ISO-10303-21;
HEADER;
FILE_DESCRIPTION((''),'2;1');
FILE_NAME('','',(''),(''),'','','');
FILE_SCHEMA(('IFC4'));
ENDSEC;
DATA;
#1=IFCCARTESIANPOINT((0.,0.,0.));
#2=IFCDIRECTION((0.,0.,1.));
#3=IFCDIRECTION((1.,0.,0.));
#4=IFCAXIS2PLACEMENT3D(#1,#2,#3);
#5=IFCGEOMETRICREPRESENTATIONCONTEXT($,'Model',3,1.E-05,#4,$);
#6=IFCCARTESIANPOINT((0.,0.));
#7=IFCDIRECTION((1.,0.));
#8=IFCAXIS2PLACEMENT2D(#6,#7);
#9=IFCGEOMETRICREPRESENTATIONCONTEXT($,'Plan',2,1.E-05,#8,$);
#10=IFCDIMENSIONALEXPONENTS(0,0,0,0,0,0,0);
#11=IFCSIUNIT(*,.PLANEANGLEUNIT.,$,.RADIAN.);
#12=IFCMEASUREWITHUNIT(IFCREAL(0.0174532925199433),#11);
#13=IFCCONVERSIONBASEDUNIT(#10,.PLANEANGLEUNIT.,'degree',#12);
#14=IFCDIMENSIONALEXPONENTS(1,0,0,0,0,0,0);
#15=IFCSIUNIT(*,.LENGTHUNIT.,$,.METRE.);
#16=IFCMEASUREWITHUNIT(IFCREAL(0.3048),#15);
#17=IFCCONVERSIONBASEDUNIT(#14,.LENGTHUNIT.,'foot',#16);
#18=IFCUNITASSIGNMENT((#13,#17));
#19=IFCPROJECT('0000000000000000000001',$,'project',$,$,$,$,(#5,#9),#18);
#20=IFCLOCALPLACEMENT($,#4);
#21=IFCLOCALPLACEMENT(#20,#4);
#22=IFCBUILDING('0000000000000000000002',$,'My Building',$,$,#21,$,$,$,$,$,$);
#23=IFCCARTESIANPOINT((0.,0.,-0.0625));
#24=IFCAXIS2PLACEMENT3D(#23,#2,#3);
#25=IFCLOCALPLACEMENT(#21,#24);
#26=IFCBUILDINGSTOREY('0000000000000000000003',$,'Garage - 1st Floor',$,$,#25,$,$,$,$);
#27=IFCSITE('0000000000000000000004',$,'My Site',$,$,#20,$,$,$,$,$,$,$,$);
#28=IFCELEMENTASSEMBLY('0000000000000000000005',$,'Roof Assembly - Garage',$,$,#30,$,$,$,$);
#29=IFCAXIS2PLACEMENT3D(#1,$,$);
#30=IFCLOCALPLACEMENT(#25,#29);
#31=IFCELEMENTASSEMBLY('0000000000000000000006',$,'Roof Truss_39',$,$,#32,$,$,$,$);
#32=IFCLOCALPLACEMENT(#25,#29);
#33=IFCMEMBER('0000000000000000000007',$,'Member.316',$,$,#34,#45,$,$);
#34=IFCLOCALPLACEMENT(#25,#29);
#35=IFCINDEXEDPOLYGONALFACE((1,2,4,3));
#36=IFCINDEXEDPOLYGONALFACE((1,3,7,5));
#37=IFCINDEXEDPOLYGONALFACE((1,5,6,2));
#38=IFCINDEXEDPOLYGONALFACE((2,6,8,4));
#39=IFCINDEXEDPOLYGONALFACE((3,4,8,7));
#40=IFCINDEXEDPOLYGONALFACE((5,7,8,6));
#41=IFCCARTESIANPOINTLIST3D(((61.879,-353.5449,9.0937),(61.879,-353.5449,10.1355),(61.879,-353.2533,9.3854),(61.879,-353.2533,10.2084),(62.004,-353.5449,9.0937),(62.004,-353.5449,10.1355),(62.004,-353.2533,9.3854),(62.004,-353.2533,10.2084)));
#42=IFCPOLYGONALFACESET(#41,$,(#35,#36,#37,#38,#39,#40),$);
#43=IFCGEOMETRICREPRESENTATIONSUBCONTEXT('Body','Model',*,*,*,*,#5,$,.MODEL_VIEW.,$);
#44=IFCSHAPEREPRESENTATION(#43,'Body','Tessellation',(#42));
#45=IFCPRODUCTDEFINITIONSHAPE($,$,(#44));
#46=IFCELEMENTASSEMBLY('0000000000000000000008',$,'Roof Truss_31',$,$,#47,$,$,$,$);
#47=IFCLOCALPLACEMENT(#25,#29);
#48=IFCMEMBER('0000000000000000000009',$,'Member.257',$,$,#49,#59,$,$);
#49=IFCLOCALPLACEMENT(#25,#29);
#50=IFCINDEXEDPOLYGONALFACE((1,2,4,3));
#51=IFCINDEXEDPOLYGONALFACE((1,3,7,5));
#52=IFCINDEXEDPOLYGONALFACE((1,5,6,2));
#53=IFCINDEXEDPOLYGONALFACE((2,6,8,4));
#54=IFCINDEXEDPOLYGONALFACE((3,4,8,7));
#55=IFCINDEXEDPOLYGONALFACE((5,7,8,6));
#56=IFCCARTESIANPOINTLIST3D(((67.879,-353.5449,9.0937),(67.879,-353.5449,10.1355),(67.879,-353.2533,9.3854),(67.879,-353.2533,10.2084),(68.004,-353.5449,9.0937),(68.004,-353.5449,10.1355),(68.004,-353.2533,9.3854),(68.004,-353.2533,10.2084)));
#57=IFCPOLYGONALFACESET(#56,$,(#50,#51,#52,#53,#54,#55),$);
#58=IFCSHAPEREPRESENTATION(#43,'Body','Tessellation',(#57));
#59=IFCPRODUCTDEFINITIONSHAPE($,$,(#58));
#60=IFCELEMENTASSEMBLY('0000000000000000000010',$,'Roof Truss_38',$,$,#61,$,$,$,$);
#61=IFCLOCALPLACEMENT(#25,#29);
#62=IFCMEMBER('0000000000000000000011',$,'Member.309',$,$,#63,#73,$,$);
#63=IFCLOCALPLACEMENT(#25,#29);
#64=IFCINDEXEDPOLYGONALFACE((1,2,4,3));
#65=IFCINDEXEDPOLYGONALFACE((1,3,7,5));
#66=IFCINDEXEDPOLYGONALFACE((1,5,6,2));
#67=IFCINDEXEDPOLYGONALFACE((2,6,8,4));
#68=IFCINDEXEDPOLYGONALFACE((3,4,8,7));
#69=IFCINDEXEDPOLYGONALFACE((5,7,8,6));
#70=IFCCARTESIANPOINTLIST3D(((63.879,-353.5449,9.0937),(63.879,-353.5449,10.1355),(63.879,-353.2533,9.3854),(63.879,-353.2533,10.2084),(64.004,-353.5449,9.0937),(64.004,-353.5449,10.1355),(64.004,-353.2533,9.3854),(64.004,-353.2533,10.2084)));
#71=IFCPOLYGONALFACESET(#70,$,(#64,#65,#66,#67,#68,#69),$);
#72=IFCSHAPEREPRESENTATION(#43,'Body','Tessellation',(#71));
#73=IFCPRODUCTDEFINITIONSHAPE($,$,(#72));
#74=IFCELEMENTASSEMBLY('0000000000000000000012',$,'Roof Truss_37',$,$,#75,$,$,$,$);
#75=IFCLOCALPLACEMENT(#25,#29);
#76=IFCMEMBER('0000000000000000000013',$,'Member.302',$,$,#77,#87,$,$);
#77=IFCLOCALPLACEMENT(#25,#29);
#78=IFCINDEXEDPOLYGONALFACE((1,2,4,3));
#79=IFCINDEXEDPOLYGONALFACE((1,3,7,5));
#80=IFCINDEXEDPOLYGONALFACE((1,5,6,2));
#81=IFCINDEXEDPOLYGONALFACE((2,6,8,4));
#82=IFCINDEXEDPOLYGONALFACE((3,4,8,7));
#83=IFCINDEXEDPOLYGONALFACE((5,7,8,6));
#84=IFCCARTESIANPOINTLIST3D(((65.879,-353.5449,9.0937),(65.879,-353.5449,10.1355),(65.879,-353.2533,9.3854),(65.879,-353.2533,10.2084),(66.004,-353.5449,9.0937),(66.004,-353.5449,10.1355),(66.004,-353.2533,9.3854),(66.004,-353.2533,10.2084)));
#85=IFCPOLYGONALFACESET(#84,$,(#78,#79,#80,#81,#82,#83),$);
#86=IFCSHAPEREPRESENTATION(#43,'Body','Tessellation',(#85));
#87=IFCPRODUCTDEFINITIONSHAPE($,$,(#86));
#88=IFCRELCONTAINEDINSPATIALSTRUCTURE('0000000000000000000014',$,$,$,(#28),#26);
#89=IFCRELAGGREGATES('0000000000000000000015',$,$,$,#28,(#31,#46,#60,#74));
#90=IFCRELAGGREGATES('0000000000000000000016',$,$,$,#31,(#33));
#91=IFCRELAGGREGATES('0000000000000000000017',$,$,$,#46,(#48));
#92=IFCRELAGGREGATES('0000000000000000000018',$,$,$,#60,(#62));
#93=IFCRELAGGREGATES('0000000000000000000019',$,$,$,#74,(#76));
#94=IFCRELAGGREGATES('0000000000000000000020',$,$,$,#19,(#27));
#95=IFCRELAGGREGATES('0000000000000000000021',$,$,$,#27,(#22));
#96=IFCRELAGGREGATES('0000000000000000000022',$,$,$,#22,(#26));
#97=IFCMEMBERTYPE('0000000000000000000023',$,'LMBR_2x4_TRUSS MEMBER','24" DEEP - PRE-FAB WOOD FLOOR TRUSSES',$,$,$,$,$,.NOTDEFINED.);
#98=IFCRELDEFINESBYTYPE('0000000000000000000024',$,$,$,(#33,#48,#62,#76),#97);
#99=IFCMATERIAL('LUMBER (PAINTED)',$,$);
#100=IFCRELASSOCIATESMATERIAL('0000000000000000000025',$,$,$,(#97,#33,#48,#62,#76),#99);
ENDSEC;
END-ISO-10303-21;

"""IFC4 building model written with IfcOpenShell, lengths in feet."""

from ifc_helpers import new_model, entity, si_unit, converted_unit, frame, origin_with_axes, origin_2d_with_axis, place, context, subcontext, project, spatial, indexed_curve, outline, extrude, clip, halfspace, material, material_profile, profile_set, profile_usage, type_object, element, aggregate, save


model = new_model("IFC4")

# Units and contexts
model_context = context("Model", 3, precision=1e-05, world=origin_with_axes())
plan_context = context("Plan", 2, precision=1e-05, world=origin_2d_with_axis())
body_context = subcontext(model_context, "Body", "Model", "MODEL_VIEW")
ifc_project = project(units=[converted_unit("PLANEANGLEUNIT", "degree", entity("IfcReal", 0.0174532925199433), si_unit("PLANEANGLEUNIT", "RADIAN"), dimensions=[0, 0, 0, 0, 0, 0, 0]), converted_unit("LENGTHUNIT", "foot", entity("IfcReal", 0.3048), si_unit("LENGTHUNIT", "METRE"), dimensions=[1, 0, 0, 0, 0, 0, 0])], contexts=[model_context, plan_context])

# Site, building, storey
site_placement = place(None, origin_with_axes())
site = spatial("IfcSite", under=ifc_project, at=site_placement, Name="My Site")
building_placement = place(site_placement, origin_with_axes())
building = spatial("IfcBuilding", under=site, at=building_placement, Name="My Building")
storey_placement = place(building_placement, frame((0.0, 0.0, -0.0625), z_axis=(0.0, 0.0, 1.0), x_axis=(1.0, 0.0, 0.0)))
storey = spatial("IfcBuildingStorey", under=building, at=storey_placement, Name="Garage - 1st Floor")

# Element assemblies, members
assembly_1_placement = place(storey_placement, frame((0.0, 0.0, 0.125), z_axis=(0.0, 0.0, 1.0), x_axis=(1.0, 0.0, 0.0)))
assembly_1 = element("IfcElementAssembly", 1, at=assembly_1_placement, inside=storey, Name="Roof Assembly - Garage")
ifc_material = material(Name="LUMBER (PAINTED)")
ifc_material_profile_1 = material_profile(ifc_material, outline(indexed_curve([(-0.0625, -0.1458), (0.0625, -0.1458), (0.0625, 0.1458), (-0.0625, 0.1458), (-0.0625, -0.1458)])))
ifc_profile_set_1 = profile_set([ifc_material_profile_1])
member_type_1 = type_object("IfcMemberType", Name="LMBR_2x4_TRUSS MEMBER", Description="24\" DEEP - PRE-FAB WOOD FLOOR TRUSSES", PredefinedType="NOTDEFINED", material=ifc_profile_set_1)
assembly_2_placement = place(assembly_1_placement, frame((61.9415, -346.0033, 12.5192), z_axis=(0.0, 0.0, 1.0), x_axis=(0.0, 1.0, 0.0)))
assembly_2 = element("IfcElementAssembly", 2, at=assembly_2_placement, Name="Roof Truss_39")
ifc_profile_usage_1 = profile_usage(ifc_profile_set_1)
member_1_placement = place(assembly_2_placement, frame((-7.3958, 0.0, -2.1806), z_axis=(0.0, 0.0, -1.0), x_axis=(0.0, 1.0, 0.0)))
member_1 = element("IfcMember", 3, at=member_1_placement, type_object=member_type_1, material=ifc_profile_usage_1, Name="Member.316", context=body_context, shape_type="Clipping", body=[
    clip(clip(extrude(outline(indexed_curve([(-0.0625, -0.1458), (0.0625, -0.1458), (0.0625, 0.1458), (-0.0625, 0.1458), (-0.0625, -0.1458)])), origin_with_axes(), (0.0, 0.0, 1.0), 1.3698), halfspace(frame((0.0, 7.5424, -1.5944), z_axis=(0.0, -0.242599, -0.970127), x_axis=(-1.0, 0.000001, 0.0)), False)), halfspace(frame((397.5032, -0.1458, 1.3698), z_axis=(0.0, 0.707107, 0.707107), x_axis=(1.0, 0.0, 0.0)), False)),
])
assembly_3_placement = place(assembly_1_placement, frame((67.9415, -346.0033, 12.5192), z_axis=(0.0, 0.0, 1.0), x_axis=(0.0, 1.0, 0.0)))
assembly_3 = element("IfcElementAssembly", 4, at=assembly_3_placement, Name="Roof Truss_31")
ifc_profile_usage_2 = profile_usage(ifc_profile_set_1)
member_2_placement = place(assembly_3_placement, frame((-7.3958, 0.0, -2.1806), z_axis=(0.0, 0.0, -1.0), x_axis=(0.0, 1.0, 0.0)))
member_2 = element("IfcMember", 5, at=member_2_placement, type_object=member_type_1, material=ifc_profile_usage_2, Name="Member.257", context=body_context, shape_type="Clipping", body=[
    clip(clip(extrude(outline(indexed_curve([(-0.0625, -0.1458), (0.0625, -0.1458), (0.0625, 0.1458), (-0.0625, 0.1458), (-0.0625, -0.1458)])), origin_with_axes(), (0.0, 0.0, 1.0), 1.3698), halfspace(frame((0.0, 7.5424, -1.5944), z_axis=(0.0, -0.242599, -0.970127), x_axis=(-1.0, 0.000001, 0.0)), False)), halfspace(frame((397.5032, -0.1458, 1.3698), z_axis=(0.0, 0.707107, 0.707107), x_axis=(1.0, 0.0, 0.0)), False)),
])
assembly_4_placement = place(assembly_1_placement, frame((63.9415, -346.0033, 12.5192), z_axis=(0.0, 0.0, 1.0), x_axis=(0.0, 1.0, 0.0)))
assembly_4 = element("IfcElementAssembly", 6, at=assembly_4_placement, Name="Roof Truss_38")
ifc_profile_usage_3 = profile_usage(ifc_profile_set_1)
member_3_placement = place(assembly_4_placement, frame((-7.3958, 0.0, -2.1806), z_axis=(0.0, 0.0, -1.0), x_axis=(0.0, 1.0, 0.0)))
member_3 = element("IfcMember", 7, at=member_3_placement, type_object=member_type_1, material=ifc_profile_usage_3, Name="Member.309", context=body_context, shape_type="Clipping", body=[
    clip(clip(extrude(outline(indexed_curve([(-0.0625, -0.1458), (0.0625, -0.1458), (0.0625, 0.1458), (-0.0625, 0.1458), (-0.0625, -0.1458)])), origin_with_axes(), (0.0, 0.0, 1.0), 1.3698), halfspace(frame((0.0, 7.5424, -1.5944), z_axis=(0.0, -0.242599, -0.970127), x_axis=(-1.0, 0.000001, 0.0)), False)), halfspace(frame((397.5032, -0.1458, 1.3698), z_axis=(0.0, 0.707107, 0.707107), x_axis=(1.0, 0.0, 0.0)), False)),
])
assembly_5_placement = place(assembly_1_placement, frame((65.9415, -346.0033, 12.5192), z_axis=(0.0, 0.0, 1.0), x_axis=(0.0, 1.0, 0.0)))
assembly_5 = element("IfcElementAssembly", 8, at=assembly_5_placement, Name="Roof Truss_37")
aggregate(assembly_1, [assembly_2, assembly_3, assembly_4, assembly_5])
ifc_profile_usage_4 = profile_usage(ifc_profile_set_1)
member_4_placement = place(assembly_5_placement, frame((-7.3958, 0.0, -2.1806), z_axis=(0.0, 0.0, -1.0), x_axis=(0.0, 1.0, 0.0)))
member_4 = element("IfcMember", 9, at=member_4_placement, type_object=member_type_1, material=ifc_profile_usage_4, Name="Member.302", context=body_context, shape_type="Clipping", body=[
    clip(clip(extrude(outline(indexed_curve([(-0.0625, -0.1458), (0.0625, -0.1458), (0.0625, 0.1458), (-0.0625, 0.1458), (-0.0625, -0.1458)])), origin_with_axes(), (0.0, 0.0, 1.0), 1.3698), halfspace(frame((0.0, 7.5424, -1.5944), z_axis=(0.0, -0.242599, -0.970127), x_axis=(-1.0, 0.000001, 0.0)), False)), halfspace(frame((397.5032, -0.1458, 1.3698), z_axis=(0.0, 0.707107, 0.707107), x_axis=(1.0, 0.0, 0.0)), False)),
])
aggregate(assembly_2, [member_1])
aggregate(assembly_3, [member_2])
aggregate(assembly_4, [member_3])
aggregate(assembly_5, [member_4])

save(model, "model.ifc")
